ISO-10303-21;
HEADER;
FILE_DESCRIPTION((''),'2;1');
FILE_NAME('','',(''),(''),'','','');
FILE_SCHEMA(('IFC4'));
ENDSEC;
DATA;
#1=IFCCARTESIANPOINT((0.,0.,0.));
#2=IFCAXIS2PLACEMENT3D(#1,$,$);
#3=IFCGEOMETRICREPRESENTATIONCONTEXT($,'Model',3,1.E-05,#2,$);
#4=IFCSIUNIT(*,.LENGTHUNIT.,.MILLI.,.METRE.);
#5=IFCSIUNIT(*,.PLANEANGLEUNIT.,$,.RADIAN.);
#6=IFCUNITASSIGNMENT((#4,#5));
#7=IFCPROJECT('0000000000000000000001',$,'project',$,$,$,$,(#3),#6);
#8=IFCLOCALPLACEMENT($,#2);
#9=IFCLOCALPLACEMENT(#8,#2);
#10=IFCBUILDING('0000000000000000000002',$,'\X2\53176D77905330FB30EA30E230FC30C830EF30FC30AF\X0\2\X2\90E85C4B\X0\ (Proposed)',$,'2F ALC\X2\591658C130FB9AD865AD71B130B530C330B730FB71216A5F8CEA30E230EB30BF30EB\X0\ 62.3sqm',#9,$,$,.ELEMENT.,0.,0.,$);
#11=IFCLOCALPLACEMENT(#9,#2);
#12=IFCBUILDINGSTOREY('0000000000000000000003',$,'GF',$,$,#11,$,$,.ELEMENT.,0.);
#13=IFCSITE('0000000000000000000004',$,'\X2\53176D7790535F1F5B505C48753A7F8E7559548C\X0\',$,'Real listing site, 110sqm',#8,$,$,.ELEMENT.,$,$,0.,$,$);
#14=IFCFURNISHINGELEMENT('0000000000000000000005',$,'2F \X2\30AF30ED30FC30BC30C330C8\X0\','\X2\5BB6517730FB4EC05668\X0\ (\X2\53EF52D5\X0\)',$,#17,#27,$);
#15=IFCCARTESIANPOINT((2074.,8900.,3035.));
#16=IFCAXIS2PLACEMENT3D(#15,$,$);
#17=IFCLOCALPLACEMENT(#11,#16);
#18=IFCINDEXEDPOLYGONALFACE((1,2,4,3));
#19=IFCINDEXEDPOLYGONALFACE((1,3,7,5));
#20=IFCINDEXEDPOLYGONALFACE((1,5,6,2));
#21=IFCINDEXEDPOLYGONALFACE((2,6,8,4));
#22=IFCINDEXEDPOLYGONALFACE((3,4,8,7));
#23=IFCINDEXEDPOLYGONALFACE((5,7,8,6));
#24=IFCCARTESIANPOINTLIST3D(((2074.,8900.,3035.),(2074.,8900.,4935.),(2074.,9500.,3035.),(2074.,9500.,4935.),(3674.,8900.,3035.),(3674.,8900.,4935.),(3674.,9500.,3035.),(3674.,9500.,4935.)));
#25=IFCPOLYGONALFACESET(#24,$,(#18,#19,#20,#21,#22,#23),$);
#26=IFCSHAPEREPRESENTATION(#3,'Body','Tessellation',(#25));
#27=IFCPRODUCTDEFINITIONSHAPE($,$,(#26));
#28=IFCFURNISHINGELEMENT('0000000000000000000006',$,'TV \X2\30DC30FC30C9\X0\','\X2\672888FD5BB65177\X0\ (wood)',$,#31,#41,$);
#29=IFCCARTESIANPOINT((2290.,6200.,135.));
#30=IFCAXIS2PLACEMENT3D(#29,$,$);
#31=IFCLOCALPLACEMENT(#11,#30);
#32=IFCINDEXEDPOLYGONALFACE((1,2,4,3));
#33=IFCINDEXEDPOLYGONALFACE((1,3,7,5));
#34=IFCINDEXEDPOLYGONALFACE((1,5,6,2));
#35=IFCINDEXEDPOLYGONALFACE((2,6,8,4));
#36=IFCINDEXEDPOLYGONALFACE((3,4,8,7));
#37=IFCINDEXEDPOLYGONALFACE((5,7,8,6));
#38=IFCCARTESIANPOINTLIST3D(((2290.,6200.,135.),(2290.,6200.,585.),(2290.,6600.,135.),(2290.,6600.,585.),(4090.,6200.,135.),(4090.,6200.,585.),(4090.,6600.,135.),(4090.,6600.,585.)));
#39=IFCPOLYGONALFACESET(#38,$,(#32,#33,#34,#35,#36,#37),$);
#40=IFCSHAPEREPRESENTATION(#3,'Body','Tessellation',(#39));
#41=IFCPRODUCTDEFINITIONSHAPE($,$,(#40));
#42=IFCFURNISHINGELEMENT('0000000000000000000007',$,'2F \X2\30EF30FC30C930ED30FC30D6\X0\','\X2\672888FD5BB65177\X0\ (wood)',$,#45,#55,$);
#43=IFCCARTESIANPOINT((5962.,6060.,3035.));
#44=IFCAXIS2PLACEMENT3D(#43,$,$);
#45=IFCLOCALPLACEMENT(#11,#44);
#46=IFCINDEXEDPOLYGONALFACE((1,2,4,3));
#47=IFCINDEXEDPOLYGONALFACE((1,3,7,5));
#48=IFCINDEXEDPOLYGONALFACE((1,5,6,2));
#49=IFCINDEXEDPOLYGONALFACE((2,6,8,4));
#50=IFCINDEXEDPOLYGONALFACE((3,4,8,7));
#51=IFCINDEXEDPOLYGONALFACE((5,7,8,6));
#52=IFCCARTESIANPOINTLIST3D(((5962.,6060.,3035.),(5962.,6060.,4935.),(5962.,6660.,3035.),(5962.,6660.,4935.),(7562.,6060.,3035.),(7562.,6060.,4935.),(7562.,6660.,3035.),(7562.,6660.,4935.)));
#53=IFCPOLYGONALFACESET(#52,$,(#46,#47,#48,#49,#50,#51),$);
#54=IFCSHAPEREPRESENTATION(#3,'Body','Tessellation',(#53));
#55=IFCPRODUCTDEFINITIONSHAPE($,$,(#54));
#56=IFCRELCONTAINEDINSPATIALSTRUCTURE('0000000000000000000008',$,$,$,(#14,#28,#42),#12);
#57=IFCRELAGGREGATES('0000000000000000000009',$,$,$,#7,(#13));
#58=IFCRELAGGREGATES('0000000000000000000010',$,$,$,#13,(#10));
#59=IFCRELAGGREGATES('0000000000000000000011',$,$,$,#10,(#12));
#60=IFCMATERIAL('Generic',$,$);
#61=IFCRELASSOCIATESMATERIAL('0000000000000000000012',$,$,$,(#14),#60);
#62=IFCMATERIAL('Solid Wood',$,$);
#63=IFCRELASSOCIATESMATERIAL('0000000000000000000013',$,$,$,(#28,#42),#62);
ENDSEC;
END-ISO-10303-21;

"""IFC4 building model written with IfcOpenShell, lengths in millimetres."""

from ifc_helpers import new_model, si_unit, frame, frame_2d, origin, place, context, project, spatial, rectangle, extrude, material, element, save


model = new_model("IFC4")

# Units and contexts
model_context = context("Model", 3, precision=1e-05, world=origin())
ifc_project = project(units=[si_unit("LENGTHUNIT", "METRE", prefix="MILLI"), si_unit("PLANEANGLEUNIT", "RADIAN")], contexts=[model_context])

# Site, building, storey
site_placement = place(None, origin())
site = spatial("IfcSite", under=ifc_project, at=site_placement, Name="北海道弟子屈町美留和", ObjectType="Real listing site, 110sqm", CompositionType="ELEMENT", RefElevation=0.0)
building_placement = place(site_placement, origin())
building = spatial("IfcBuilding", under=site, at=building_placement, Name="北海道・リモートワーク2部屋 (Proposed)", ObjectType="2F ALC外壁・高断熱サッシ・無機質モルタル 62.3sqm", CompositionType="ELEMENT", ElevationOfRefHeight=0.0, ElevationOfTerrain=0.0)
storey_placement = place(building_placement, origin())
storey = spatial("IfcBuildingStorey", under=building, at=storey_placement, Name="GF", CompositionType="ELEMENT", Elevation=0.0)

# Shared definitions
ifc_material_1 = material(Name="Solid Wood")

# Shared definitions
ifc_material_2 = material(Name="Generic")

# Furnishing elements
furnishing_1_placement = place(storey_placement, frame((2074.0, 8900.0, 3035.0)))
element("IfcFurnishingElement", 1, at=furnishing_1_placement, inside=storey, material=ifc_material_2, Name="2F クローゼット", Description="家具・什器 (可動)", context=model_context, shape_type="SweptSolid", body=[
    extrude(rectangle(XDim=1600.0, YDim=600.0, at=frame_2d((800.0, 300.0))), frame((2074.0, 8900.0, 3035.0)), (0.0, 0.0, 1.0), 1900.0),
])
furnishing_2_placement = place(storey_placement, frame((2290.0, 6200.0, 135.0)))
element("IfcFurnishingElement", 2, at=furnishing_2_placement, inside=storey, material=ifc_material_1, Name="TV ボード", Description="木製家具 (wood)", context=model_context, shape_type="SweptSolid", body=[
    extrude(rectangle(XDim=1800.0, YDim=400.0, at=frame_2d((900.0, 200.0))), frame((2290.0, 6200.0, 135.0)), (0.0, 0.0, 1.0), 450.0),
])
furnishing_3_placement = place(storey_placement, frame((5962.0, 6060.0, 3035.0)))
element("IfcFurnishingElement", 3, at=furnishing_3_placement, inside=storey, material=ifc_material_1, Name="2F ワードローブ", Description="木製家具 (wood)", context=model_context, shape_type="SweptSolid", body=[
    extrude(rectangle(XDim=1600.0, YDim=600.0, at=frame_2d((800.0, 300.0))), frame((5962.0, 6060.0, 3035.0)), (0.0, 0.0, 1.0), 1900.0),
])

save(model, "model.ifc")
